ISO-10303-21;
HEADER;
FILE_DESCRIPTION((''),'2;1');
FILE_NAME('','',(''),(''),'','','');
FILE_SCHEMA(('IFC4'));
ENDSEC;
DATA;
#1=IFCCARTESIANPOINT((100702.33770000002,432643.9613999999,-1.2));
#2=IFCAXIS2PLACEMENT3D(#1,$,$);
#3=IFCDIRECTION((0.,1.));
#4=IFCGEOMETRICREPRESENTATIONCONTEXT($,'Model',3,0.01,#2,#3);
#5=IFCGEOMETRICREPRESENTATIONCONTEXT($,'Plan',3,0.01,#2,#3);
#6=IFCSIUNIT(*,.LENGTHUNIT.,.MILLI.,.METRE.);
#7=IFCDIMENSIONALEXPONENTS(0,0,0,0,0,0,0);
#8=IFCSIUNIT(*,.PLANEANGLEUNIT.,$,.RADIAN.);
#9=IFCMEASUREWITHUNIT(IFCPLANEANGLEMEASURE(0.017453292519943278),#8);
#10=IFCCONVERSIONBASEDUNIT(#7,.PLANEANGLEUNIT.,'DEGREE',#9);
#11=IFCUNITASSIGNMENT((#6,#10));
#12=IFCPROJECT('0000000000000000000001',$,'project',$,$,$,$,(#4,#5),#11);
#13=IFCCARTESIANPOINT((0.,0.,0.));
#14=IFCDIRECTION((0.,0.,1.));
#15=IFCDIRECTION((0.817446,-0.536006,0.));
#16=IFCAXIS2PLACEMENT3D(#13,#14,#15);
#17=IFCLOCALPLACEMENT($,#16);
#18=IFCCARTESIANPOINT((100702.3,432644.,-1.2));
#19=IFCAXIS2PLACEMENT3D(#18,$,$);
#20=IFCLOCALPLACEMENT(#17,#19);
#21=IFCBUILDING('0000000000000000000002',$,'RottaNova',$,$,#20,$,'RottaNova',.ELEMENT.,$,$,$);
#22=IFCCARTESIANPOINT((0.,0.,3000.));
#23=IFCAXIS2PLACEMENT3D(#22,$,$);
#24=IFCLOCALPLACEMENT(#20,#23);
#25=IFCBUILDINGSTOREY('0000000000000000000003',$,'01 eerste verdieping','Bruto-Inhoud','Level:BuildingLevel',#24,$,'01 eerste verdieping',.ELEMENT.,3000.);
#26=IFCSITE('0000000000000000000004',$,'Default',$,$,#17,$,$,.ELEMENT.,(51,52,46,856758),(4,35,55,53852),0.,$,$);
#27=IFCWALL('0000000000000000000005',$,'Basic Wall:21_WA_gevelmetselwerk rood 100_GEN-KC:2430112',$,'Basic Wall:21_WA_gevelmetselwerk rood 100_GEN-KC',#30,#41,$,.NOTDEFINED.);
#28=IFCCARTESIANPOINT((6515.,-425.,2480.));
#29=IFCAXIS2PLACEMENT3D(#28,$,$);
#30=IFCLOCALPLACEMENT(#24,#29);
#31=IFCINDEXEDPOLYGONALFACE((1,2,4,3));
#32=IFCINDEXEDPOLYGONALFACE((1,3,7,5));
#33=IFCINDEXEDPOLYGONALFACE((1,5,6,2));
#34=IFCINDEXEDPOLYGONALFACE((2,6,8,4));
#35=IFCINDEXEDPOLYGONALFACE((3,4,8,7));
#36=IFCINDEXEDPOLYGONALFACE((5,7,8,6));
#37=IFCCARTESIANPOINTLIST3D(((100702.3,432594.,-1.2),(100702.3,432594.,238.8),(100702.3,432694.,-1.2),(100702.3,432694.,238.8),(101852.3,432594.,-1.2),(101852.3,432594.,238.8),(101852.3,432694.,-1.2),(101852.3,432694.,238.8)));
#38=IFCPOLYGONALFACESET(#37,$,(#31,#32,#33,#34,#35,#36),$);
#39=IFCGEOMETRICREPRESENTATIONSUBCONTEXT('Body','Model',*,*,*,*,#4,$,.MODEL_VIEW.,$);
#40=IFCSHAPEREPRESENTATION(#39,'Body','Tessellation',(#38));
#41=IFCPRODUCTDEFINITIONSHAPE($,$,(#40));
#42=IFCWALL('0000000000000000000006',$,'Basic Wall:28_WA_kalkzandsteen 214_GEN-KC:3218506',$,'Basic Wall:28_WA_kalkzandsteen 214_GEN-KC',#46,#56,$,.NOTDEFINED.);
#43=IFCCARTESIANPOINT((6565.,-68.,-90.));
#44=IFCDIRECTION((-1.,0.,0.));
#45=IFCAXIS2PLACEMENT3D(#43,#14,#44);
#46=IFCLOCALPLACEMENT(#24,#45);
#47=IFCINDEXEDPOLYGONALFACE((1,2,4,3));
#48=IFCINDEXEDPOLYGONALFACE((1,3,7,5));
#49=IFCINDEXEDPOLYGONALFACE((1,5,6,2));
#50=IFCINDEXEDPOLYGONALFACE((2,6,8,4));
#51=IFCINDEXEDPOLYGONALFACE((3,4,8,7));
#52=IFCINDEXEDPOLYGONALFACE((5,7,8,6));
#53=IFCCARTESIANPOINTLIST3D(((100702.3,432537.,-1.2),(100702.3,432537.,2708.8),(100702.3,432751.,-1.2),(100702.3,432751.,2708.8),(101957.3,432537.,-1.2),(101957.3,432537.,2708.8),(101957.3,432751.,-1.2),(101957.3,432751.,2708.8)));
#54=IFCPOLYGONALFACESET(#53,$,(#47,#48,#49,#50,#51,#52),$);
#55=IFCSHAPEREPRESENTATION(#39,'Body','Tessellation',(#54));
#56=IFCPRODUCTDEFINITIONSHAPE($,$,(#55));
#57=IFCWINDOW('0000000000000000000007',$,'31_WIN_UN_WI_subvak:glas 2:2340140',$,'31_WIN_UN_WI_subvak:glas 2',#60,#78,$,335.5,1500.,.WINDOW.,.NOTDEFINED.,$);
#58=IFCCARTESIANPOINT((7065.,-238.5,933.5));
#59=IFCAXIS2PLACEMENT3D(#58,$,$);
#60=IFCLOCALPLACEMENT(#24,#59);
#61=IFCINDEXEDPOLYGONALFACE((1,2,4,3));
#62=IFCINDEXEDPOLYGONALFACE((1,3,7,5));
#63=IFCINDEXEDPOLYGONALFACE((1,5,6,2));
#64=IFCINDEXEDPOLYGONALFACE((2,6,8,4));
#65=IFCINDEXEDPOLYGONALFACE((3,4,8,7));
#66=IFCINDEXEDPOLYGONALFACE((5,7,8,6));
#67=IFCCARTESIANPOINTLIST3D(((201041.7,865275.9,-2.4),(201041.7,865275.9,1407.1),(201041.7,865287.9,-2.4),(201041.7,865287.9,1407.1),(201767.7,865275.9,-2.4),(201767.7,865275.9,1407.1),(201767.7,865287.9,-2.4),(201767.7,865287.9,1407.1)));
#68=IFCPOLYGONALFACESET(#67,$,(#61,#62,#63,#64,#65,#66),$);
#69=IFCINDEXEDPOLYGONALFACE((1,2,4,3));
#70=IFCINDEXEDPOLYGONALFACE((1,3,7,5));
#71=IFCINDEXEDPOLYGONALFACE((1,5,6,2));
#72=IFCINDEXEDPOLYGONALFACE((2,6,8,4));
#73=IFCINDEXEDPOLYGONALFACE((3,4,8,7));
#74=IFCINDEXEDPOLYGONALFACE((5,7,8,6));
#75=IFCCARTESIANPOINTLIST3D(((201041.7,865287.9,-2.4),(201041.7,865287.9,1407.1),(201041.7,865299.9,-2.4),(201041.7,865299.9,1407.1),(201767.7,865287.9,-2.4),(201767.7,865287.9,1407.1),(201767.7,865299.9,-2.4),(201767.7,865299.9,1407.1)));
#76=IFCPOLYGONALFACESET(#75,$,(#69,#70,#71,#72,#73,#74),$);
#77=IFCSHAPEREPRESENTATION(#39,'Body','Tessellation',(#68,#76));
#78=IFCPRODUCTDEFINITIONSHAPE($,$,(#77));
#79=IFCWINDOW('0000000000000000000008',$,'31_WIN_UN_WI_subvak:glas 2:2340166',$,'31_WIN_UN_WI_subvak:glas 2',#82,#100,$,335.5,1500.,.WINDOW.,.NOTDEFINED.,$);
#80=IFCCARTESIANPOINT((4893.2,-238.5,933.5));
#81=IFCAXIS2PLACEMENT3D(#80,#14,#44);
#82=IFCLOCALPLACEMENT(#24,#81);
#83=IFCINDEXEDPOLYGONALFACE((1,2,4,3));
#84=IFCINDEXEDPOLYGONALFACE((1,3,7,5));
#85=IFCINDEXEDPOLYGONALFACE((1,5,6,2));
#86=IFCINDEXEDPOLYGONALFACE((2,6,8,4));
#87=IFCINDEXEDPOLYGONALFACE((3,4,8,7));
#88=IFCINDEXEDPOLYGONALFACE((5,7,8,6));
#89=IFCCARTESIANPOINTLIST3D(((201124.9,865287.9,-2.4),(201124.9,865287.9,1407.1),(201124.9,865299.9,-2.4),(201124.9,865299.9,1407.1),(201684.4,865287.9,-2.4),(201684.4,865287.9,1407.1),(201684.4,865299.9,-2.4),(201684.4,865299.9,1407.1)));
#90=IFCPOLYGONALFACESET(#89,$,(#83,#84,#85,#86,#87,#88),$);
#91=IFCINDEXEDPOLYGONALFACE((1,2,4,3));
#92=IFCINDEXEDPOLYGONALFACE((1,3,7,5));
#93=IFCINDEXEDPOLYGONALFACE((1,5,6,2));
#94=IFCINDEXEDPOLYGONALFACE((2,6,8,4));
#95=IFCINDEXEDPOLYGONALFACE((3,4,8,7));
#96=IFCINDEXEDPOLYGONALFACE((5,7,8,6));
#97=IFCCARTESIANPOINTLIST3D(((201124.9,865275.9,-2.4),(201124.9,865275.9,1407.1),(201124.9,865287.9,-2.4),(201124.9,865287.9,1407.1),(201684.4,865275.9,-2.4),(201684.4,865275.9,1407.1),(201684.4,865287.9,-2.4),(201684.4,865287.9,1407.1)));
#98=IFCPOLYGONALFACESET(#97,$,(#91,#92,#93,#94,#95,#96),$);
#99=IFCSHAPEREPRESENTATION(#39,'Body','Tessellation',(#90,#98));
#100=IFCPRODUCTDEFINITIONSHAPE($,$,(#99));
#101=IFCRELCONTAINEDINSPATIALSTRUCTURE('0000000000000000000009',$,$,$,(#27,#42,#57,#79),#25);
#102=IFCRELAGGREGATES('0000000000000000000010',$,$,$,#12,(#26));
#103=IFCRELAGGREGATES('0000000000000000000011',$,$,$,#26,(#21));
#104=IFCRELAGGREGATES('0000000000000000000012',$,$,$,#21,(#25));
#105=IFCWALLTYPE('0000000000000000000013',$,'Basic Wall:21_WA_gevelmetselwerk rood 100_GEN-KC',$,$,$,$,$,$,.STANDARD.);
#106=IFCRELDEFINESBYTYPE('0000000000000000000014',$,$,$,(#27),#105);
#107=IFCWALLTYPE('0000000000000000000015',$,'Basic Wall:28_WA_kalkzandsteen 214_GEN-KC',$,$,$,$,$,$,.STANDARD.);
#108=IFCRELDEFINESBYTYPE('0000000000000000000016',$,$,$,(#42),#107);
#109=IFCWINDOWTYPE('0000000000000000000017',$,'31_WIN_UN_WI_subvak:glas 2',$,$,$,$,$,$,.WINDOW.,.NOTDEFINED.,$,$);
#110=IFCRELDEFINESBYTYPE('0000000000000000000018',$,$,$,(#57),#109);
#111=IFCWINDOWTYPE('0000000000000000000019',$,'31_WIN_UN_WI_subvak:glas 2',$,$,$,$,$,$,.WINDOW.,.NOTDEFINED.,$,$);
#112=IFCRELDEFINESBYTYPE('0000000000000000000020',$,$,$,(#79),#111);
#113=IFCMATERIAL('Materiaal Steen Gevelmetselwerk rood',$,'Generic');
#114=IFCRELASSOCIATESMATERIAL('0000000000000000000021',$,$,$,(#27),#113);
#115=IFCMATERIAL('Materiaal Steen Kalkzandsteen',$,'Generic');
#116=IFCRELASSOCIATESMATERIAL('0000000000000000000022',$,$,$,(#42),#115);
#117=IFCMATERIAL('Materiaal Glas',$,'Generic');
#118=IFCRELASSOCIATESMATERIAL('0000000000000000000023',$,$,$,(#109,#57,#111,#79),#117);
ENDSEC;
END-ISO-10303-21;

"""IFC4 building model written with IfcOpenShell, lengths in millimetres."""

from ifc_helpers import new_model, entity, si_unit, converted_unit, direction, frame, place, context, subcontext, project, spatial, indexed_curve, outline, extrude, source, transform, mapped, material, type_object, type_shapes, element, save


model = new_model("IFC4")

# Units and contexts
model_context = context("Model", 3, precision=0.01, world=frame((100702.33770000002, 432643.9613999999, -1.2)), true_north=direction((0.0, 1.0)))
plan_context = context("Plan", 3, precision=0.01, world=frame((100702.33770000002, 432643.9613999999, -1.2)), true_north=direction((0.0, 1.0)))
body_context = subcontext(model_context, "Body", "Model", "MODEL_VIEW")
ifc_project = project(units=[si_unit("LENGTHUNIT", "METRE", prefix="MILLI"), converted_unit("PLANEANGLEUNIT", "DEGREE", entity("IfcPlaneAngleMeasure", 0.017453292519943278), si_unit("PLANEANGLEUNIT", "RADIAN"), dimensions=[0, 0, 0, 0, 0, 0, 0])], contexts=[model_context, plan_context])

# Site, building, storey
site_placement = place(None, frame((0.0, 0.0, 0.0), z_axis=(0.0, 0.0, 1.0), x_axis=(0.817446, -0.536006, 0.0)))
site = spatial("IfcSite", under=ifc_project, at=site_placement, Name="Default", CompositionType="ELEMENT", RefLatitude=(51, 52, 46, 856758), RefLongitude=(4, 35, 55, 53852), RefElevation=0.0)
building_placement = place(site_placement, frame((100702.3, 432644.0, -1.2)))
building = spatial("IfcBuilding", under=site, at=building_placement, Name="RottaNova", LongName="RottaNova", CompositionType="ELEMENT")
storey_placement = place(building_placement, frame((0.0, 0.0, 3000.0)))
storey = spatial("IfcBuildingStorey", under=building, at=storey_placement, Name="01 eerste verdieping", Description="Bruto-Inhoud", ObjectType="Level:BuildingLevel", LongName="01 eerste verdieping", CompositionType="ELEMENT", Elevation=3000.0)

# Shared definitions
ifc_material_1 = material(Name="Materiaal Glas", Category="Generic")

# Walls
ifc_material_2 = material(Name="Materiaal Steen Gevelmetselwerk rood", Category="Generic")
wall_type_1 = type_object("IfcWallType", Name="Basic Wall:21_WA_gevelmetselwerk rood 100_GEN-KC", PredefinedType="STANDARD")
wall_1_placement = place(storey_placement, frame((6515.0, -425.0, 2480.0)))
element("IfcWall", 1, at=wall_1_placement, inside=storey, type_object=wall_type_1, material=ifc_material_2, Name="Basic Wall:21_WA_gevelmetselwerk rood 100_GEN-KC:2430112", ObjectType="Basic Wall:21_WA_gevelmetselwerk rood 100_GEN-KC", PredefinedType="NOTDEFINED", context=body_context, shape_type="SweptSolid", body=[
    extrude(outline(indexed_curve([(1150.0, 50.0), (0.0, 50.0), (0.0, -50.0), (1150.0, -50.0), (1150.0, 50.0)], self_intersect=False)), frame((100702.3, 432644.0, -1.2)), (0.0, 0.0, 1.0), 240.0),
])
ifc_material_3 = material(Name="Materiaal Steen Kalkzandsteen", Category="Generic")
wall_type_2 = type_object("IfcWallType", Name="Basic Wall:28_WA_kalkzandsteen 214_GEN-KC", PredefinedType="STANDARD")
wall_2_placement = place(storey_placement, frame((6565.0, -68.0, -90.0), z_axis=(0.0, 0.0, 1.0), x_axis=(-1.0, 0.0, 0.0)))
element("IfcWall", 2, at=wall_2_placement, inside=storey, type_object=wall_type_2, material=ifc_material_3, Name="Basic Wall:28_WA_kalkzandsteen 214_GEN-KC:3218506", ObjectType="Basic Wall:28_WA_kalkzandsteen 214_GEN-KC", PredefinedType="NOTDEFINED", context=body_context, shape_type="SweptSolid", body=[
    extrude(outline(indexed_curve([(1255.0, 107.0), (0.0, 107.0), (0.0, -107.0), (1255.0, -107.0), (1255.0, 107.0)], self_intersect=False)), frame((100702.3, 432644.0, -1.2)), (0.0, 0.0, 1.0), 2710.0),
])

# Windows
window_type_1 = type_object("IfcWindowType", Name="31_WIN_UN_WI_subvak:glas 2", PartitioningType="NOTDEFINED", PredefinedType="WINDOW", material=ifc_material_1)
shared_shape_1 = source(frame((100702.3, 432644.0, -1.2)), body_context, "Body", "SweptSolid", [
    extrude(outline(indexed_curve([(-363.0, -6.0), (363.0, -6.0), (363.0, 6.0), (-363.0, 6.0), (-363.0, -6.0)], self_intersect=False)), frame((0.0, -6.0, 0.0)), (0.0, 0.0, 1.0), 1409.5),
    extrude(outline(indexed_curve([(-363.0, -6.0), (363.0, -6.0), (363.0, 6.0), (-363.0, 6.0), (-363.0, -6.0)], self_intersect=False)), frame((0.0, 6.0, 0.0)), (0.0, 0.0, 1.0), 1409.5),
])
type_shapes(window_type_1, [shared_shape_1])
window_1_placement = place(storey_placement, frame((7065.0, -238.5, 933.5)))
element("IfcWindow", 3, at=window_1_placement, inside=storey, type_object=window_type_1, material=ifc_material_1, Name="31_WIN_UN_WI_subvak:glas 2:2340140", ObjectType="31_WIN_UN_WI_subvak:glas 2", OverallHeight=335.5, OverallWidth=1500.0, PartitioningType="NOTDEFINED", PredefinedType="WINDOW", context=body_context, shape_type="MappedRepresentation", body=[
    mapped(shared_shape_1, transform((100702.3, 432644.0, -1.2), scale=1.0)),
])
window_type_2 = type_object("IfcWindowType", Name="31_WIN_UN_WI_subvak:glas 2", PartitioningType="NOTDEFINED", PredefinedType="WINDOW", material=ifc_material_1)
shared_shape_2 = source(frame((100702.3, 432644.0, -1.2)), body_context, "Body", "SweptSolid", [
    extrude(outline(indexed_curve([(-6.0, -279.8), (6.0, -279.8), (6.0, 279.8), (-6.0, 279.8), (-6.0, -279.8)], self_intersect=False)), frame((0.0, 6.0, 0.0), z_axis=(0.0, 0.0, 1.0), x_axis=(0.0, -1.0, 0.0)), (0.0, 0.0, 1.0), 1409.5),
    extrude(outline(indexed_curve([(-6.0, -279.8), (6.0, -279.8), (6.0, 279.8), (-6.0, 279.8), (-6.0, -279.8)], self_intersect=False)), frame((0.0, -6.0, 0.0), z_axis=(0.0, 0.0, 1.0), x_axis=(0.0, -1.0, 0.0)), (0.0, 0.0, 1.0), 1409.5),
])
type_shapes(window_type_2, [shared_shape_2])
window_2_placement = place(storey_placement, frame((4893.2, -238.5, 933.5), z_axis=(0.0, 0.0, 1.0), x_axis=(-1.0, 0.0, 0.0)))
element("IfcWindow", 4, at=window_2_placement, inside=storey, type_object=window_type_2, material=ifc_material_1, Name="31_WIN_UN_WI_subvak:glas 2:2340166", ObjectType="31_WIN_UN_WI_subvak:glas 2", OverallHeight=335.5, OverallWidth=1500.0, PartitioningType="NOTDEFINED", PredefinedType="WINDOW", context=body_context, shape_type="MappedRepresentation", body=[
    mapped(shared_shape_2, transform((100702.3, 432644.0, -1.2), scale=1.0)),
])

save(model, "model.ifc")
